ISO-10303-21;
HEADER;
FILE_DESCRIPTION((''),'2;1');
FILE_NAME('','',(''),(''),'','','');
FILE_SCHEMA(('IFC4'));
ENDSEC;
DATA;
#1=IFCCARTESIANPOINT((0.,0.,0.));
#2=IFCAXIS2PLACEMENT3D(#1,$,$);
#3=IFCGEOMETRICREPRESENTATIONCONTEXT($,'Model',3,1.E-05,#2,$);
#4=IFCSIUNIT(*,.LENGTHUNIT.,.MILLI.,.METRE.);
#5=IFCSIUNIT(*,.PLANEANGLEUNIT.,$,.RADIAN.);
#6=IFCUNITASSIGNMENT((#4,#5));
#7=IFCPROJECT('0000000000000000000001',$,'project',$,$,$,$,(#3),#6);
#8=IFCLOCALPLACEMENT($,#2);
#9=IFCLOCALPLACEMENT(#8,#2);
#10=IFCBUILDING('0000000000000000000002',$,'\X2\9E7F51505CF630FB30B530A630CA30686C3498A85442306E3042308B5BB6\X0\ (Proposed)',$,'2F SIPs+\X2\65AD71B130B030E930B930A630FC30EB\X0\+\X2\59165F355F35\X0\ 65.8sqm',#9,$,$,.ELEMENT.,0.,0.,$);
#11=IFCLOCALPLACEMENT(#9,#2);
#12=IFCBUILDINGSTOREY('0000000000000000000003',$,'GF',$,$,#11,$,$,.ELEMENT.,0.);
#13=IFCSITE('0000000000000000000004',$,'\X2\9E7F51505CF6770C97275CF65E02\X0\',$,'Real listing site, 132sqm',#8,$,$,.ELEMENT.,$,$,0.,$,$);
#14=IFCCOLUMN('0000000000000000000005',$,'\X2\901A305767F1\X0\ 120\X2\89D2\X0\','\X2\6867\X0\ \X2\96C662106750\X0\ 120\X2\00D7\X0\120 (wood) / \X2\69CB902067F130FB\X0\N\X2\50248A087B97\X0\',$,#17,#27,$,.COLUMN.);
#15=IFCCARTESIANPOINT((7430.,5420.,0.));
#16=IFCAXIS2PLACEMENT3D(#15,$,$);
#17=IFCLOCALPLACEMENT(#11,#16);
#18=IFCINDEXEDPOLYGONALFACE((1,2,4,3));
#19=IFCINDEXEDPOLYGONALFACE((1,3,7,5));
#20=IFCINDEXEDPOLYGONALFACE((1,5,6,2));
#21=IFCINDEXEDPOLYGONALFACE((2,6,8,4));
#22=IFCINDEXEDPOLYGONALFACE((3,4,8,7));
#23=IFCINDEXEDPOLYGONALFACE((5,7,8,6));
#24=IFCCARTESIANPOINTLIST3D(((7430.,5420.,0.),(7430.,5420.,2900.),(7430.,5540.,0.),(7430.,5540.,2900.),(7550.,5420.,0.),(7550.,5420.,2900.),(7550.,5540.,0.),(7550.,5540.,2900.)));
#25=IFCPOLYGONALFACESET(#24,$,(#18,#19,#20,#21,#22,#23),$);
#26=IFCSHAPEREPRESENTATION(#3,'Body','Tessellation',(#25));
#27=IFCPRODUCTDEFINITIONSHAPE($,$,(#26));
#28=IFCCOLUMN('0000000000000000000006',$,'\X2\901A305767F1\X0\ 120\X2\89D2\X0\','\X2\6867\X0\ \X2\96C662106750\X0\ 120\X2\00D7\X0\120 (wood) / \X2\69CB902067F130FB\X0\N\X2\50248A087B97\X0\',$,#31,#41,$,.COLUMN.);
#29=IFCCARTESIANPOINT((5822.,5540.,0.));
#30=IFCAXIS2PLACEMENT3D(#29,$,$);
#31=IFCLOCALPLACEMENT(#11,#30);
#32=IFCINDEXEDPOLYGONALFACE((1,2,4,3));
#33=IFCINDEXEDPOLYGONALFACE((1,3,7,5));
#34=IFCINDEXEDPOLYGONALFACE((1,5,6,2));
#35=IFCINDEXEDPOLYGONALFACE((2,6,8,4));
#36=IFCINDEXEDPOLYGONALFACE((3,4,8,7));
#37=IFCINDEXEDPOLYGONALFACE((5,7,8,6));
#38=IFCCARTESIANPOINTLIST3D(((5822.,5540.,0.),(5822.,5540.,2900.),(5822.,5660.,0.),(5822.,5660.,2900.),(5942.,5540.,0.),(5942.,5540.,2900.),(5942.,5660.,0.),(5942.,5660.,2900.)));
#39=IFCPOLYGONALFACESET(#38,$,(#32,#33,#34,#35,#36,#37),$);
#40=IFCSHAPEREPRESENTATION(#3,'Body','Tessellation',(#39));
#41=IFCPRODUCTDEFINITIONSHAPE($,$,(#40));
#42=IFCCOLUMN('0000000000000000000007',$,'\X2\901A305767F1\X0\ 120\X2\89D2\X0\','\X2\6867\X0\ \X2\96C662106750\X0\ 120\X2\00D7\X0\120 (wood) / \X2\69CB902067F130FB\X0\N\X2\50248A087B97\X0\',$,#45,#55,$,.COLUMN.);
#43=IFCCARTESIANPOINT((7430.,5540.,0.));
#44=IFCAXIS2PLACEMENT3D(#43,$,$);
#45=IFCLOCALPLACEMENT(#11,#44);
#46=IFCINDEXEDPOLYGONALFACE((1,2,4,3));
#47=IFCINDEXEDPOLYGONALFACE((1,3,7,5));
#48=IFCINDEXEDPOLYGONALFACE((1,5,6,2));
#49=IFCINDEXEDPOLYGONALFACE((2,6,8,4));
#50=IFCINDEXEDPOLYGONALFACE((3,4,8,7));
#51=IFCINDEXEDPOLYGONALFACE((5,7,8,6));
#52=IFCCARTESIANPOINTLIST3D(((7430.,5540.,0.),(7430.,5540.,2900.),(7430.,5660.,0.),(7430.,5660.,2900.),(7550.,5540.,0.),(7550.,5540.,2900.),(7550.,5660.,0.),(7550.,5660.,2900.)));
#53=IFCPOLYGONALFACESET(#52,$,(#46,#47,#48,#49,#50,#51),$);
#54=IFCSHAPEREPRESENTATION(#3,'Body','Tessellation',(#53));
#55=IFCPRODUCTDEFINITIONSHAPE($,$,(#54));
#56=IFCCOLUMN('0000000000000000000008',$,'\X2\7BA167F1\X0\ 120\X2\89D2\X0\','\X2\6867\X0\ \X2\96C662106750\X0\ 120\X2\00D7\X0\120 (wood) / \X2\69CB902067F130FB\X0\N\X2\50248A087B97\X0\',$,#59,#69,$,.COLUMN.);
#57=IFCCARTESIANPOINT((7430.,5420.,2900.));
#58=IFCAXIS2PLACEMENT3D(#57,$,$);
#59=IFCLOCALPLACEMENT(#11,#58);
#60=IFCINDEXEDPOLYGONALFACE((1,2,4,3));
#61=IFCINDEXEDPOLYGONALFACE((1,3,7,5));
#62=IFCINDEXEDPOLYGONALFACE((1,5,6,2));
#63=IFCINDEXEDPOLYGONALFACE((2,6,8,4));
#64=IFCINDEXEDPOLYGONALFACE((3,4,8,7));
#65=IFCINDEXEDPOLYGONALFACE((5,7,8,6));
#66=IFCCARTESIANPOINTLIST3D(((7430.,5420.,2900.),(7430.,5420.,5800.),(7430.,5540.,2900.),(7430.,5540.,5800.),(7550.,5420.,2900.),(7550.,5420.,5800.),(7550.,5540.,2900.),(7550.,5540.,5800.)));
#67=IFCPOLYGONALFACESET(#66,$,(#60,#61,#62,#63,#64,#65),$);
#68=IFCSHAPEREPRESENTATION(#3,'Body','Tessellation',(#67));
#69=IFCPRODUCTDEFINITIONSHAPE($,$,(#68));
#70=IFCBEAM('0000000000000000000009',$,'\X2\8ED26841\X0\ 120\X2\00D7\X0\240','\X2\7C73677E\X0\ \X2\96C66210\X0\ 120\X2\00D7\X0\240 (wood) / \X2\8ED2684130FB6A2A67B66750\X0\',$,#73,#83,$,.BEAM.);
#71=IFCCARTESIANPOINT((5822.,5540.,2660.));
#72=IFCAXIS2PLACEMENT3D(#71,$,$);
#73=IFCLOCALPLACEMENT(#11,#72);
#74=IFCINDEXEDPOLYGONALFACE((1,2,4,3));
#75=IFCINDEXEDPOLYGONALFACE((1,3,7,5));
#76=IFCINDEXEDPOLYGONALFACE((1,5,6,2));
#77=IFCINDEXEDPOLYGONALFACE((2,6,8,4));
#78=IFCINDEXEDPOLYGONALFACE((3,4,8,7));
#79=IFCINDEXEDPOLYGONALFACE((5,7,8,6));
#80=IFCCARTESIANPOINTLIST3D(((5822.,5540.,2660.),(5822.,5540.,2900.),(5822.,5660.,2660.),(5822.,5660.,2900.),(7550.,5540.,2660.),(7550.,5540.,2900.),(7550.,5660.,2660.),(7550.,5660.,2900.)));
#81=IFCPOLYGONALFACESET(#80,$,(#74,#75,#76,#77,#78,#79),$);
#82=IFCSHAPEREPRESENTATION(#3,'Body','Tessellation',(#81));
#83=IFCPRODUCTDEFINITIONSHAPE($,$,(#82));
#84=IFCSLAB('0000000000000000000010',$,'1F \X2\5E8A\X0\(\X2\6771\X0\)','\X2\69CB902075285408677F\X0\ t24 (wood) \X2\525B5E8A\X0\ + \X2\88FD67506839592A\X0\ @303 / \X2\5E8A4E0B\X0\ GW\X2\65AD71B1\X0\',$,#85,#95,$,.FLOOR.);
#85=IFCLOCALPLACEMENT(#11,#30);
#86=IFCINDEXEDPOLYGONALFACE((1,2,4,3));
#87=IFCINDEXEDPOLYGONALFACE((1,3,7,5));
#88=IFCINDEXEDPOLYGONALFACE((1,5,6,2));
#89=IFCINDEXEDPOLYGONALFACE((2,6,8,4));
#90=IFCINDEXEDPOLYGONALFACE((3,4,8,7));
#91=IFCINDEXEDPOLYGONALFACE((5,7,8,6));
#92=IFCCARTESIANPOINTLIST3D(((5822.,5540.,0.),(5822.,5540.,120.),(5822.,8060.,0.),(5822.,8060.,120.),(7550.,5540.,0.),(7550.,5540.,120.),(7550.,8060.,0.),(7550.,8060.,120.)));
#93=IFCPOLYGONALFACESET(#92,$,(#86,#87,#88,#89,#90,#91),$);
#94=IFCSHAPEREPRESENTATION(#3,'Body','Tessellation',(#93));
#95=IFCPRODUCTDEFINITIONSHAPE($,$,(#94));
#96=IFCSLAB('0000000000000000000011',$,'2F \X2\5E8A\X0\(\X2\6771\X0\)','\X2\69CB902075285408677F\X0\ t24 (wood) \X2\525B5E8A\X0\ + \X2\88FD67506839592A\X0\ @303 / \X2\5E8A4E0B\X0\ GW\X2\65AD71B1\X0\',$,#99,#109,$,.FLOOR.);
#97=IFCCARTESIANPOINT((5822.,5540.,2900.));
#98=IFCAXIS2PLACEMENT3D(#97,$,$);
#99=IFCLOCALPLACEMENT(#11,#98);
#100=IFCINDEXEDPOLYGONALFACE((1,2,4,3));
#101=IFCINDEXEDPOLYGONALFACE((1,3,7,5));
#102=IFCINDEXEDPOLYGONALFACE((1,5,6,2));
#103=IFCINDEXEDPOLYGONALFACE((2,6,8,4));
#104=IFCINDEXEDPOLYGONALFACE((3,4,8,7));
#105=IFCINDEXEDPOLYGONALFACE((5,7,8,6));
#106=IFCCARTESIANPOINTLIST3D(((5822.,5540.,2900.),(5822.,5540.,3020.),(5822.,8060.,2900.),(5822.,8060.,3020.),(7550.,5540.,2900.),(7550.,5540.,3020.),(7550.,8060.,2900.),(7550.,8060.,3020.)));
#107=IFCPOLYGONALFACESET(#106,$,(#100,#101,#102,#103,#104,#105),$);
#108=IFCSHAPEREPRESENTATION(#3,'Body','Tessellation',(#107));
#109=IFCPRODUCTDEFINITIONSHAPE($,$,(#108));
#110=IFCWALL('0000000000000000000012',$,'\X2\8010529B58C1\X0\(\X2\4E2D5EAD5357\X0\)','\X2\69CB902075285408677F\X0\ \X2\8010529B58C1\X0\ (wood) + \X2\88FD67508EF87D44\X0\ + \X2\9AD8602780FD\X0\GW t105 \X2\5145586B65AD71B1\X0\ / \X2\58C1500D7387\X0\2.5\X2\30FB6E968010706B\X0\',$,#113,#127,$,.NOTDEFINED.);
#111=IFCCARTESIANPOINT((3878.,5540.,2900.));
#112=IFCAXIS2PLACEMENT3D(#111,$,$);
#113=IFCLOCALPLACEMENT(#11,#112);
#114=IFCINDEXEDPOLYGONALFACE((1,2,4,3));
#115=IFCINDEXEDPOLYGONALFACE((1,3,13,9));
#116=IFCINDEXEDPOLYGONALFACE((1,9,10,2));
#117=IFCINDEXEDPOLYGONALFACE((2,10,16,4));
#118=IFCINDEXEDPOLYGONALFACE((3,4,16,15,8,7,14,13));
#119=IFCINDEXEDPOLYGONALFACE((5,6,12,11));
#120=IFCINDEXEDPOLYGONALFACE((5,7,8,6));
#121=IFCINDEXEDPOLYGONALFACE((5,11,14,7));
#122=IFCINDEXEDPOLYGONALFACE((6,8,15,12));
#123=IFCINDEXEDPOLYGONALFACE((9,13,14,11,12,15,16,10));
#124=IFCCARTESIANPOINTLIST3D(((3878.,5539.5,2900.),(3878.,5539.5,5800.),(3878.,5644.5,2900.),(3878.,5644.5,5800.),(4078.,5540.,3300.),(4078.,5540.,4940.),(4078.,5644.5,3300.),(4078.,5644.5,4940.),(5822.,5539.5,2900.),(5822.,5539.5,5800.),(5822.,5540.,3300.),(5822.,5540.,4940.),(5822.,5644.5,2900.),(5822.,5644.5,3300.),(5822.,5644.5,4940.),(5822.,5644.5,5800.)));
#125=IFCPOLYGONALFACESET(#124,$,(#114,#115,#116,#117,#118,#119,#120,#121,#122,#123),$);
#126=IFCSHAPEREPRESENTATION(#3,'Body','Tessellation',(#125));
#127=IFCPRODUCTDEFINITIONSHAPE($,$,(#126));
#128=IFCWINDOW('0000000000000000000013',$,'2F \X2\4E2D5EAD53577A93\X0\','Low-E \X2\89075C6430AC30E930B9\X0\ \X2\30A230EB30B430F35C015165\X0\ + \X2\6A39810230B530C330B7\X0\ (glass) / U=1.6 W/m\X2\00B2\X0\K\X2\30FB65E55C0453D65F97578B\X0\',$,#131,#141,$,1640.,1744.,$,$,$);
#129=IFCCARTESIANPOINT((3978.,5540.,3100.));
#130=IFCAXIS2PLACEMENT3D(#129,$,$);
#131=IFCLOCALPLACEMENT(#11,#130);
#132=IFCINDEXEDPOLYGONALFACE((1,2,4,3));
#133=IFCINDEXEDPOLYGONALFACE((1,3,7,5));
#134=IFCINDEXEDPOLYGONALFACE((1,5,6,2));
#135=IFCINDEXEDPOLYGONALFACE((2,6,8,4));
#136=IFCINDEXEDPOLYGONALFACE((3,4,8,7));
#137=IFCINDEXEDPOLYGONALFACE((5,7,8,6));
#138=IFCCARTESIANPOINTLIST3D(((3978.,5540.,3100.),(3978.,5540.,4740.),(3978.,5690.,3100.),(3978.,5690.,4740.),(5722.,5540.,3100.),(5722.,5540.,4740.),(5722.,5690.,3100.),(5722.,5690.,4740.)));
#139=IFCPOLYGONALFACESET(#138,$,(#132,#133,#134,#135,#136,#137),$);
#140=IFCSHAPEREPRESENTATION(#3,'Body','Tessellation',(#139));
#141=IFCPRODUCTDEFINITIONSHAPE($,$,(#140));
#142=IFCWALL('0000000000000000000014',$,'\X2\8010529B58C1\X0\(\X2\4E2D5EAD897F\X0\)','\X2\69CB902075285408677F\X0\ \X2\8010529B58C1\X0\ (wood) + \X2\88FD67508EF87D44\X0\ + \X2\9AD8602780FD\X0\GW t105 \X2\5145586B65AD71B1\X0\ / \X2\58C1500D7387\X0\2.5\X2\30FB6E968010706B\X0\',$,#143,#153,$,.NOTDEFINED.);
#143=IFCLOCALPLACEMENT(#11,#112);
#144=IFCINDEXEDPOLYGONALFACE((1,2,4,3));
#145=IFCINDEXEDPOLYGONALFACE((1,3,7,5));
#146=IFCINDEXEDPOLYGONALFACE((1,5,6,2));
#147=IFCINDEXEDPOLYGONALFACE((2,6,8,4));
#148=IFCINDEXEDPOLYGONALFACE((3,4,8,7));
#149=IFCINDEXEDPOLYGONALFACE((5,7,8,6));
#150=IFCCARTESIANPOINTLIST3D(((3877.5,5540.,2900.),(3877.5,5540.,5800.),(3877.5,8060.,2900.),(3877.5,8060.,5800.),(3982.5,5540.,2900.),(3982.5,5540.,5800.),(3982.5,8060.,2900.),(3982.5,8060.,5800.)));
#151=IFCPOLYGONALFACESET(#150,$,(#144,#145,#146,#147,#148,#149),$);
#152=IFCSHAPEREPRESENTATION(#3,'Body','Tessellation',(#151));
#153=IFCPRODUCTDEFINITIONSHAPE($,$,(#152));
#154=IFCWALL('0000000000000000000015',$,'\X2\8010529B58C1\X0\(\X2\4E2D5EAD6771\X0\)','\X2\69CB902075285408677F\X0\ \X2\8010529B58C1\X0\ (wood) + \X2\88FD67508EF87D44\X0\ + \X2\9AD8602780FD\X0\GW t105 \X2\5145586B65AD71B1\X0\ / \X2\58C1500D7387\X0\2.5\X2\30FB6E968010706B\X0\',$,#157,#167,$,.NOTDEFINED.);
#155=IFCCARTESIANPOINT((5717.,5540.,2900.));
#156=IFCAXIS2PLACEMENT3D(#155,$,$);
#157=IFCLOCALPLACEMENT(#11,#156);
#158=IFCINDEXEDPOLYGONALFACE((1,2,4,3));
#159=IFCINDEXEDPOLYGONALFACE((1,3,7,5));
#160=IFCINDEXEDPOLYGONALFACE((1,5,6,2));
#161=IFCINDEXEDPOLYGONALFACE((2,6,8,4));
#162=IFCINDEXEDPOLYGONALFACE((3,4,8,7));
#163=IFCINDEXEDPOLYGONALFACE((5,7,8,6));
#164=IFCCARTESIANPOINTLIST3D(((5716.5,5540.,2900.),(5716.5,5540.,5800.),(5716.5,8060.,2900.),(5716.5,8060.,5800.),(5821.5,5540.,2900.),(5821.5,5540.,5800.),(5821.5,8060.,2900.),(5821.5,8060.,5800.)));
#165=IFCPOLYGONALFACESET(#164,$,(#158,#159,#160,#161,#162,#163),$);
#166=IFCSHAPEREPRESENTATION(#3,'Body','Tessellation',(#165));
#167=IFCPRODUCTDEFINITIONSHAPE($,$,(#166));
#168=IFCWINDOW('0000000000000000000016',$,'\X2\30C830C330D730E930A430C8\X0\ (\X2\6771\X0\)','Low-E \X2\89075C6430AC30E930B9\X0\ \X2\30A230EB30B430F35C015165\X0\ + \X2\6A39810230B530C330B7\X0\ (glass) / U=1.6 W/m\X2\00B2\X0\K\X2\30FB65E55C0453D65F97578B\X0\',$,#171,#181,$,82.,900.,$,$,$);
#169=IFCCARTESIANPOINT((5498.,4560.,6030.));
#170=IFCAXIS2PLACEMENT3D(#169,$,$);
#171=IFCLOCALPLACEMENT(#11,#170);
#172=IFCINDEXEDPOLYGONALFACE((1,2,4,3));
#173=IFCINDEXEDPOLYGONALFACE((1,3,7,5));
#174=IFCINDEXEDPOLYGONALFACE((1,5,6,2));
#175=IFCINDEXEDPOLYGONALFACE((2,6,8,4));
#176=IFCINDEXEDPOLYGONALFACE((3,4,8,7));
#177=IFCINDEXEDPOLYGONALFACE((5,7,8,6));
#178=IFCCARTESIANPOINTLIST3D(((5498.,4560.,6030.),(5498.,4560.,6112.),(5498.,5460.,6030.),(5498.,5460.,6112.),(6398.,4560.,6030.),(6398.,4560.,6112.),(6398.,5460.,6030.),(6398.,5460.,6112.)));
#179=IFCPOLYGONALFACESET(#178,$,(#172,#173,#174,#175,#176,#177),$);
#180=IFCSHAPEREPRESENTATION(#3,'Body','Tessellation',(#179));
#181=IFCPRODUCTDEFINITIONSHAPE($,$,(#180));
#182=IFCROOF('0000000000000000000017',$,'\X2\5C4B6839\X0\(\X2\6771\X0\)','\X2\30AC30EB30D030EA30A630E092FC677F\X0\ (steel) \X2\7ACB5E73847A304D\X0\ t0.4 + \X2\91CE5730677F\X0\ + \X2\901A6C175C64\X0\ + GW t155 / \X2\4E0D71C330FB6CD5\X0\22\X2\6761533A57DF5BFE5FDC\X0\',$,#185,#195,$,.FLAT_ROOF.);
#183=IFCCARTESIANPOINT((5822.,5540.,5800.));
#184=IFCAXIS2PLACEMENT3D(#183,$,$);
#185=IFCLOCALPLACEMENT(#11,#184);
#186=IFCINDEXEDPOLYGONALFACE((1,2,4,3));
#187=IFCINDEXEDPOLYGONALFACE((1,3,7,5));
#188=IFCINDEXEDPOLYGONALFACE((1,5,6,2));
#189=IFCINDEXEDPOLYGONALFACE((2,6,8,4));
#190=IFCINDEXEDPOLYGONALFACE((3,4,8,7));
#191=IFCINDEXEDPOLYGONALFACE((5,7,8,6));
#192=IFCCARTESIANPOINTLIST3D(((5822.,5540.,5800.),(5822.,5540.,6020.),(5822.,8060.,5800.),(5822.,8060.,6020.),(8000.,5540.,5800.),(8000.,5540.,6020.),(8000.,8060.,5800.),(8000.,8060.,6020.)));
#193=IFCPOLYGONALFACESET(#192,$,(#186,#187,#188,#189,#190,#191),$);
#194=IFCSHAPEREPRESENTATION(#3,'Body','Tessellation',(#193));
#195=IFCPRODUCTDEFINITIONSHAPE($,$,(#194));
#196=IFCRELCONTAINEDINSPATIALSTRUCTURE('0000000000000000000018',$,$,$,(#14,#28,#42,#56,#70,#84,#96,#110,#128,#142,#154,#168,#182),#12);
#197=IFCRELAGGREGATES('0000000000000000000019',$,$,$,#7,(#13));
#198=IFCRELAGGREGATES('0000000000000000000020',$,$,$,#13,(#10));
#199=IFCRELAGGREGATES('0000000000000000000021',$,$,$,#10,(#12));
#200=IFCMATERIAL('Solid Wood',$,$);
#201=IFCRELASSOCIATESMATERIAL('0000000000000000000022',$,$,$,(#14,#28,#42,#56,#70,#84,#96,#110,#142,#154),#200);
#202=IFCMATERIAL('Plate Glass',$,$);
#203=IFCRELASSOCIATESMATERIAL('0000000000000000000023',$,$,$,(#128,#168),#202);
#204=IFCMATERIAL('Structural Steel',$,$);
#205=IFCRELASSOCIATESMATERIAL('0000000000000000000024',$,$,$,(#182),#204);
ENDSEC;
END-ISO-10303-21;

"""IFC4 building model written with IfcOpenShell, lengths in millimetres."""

from ifc_helpers import new_model, si_unit, frame, frame_2d, origin, place, context, project, spatial, rectangle, extrude, material, element, fill, save


model = new_model("IFC4")

# Units and contexts
model_context = context("Model", 3, precision=1e-05, world=origin())
ifc_project = project(units=[si_unit("LENGTHUNIT", "METRE", prefix="MILLI"), si_unit("PLANEANGLEUNIT", "RADIAN")], contexts=[model_context])

# Site, building, storey
site_placement = place(None, origin())
site = spatial("IfcSite", under=ifc_project, at=site_placement, Name="鹿児島県霧島市", ObjectType="Real listing site, 132sqm", CompositionType="ELEMENT", RefElevation=0.0)
building_placement = place(site_placement, origin())
building = spatial("IfcBuilding", under=site, at=building_placement, Name="鹿児島・サウナと水風呂のある家 (Proposed)", ObjectType="2F SIPs+断熱グラスウール+外張張 65.8sqm", CompositionType="ELEMENT", ElevationOfRefHeight=0.0, ElevationOfTerrain=0.0)
storey_placement = place(building_placement, origin())
storey = spatial("IfcBuildingStorey", under=building, at=storey_placement, Name="GF", CompositionType="ELEMENT", Elevation=0.0)

# Columns
ifc_material_1 = material(Name="Solid Wood")
column_1_placement = place(storey_placement, frame((7430.0, 5420.0, 0.0)))
element("IfcColumn", 1, at=column_1_placement, inside=storey, material=ifc_material_1, Name="通し柱 120角", Description="桧 集成材 120×120 (wood) / 構造柱・N値計算", PredefinedType="COLUMN", context=model_context, shape_type="SweptSolid", body=[
    extrude(rectangle(XDim=120.0, YDim=120.0, at=frame_2d((60.0, 60.0))), frame((7430.0, 5420.0, 0.0)), (0.0, 0.0, 1.0), 2900.0),
])
column_2_placement = place(storey_placement, frame((5822.0, 5540.0, 0.0)))
element("IfcColumn", 2, at=column_2_placement, inside=storey, material=ifc_material_1, Name="通し柱 120角", Description="桧 集成材 120×120 (wood) / 構造柱・N値計算", PredefinedType="COLUMN", context=model_context, shape_type="SweptSolid", body=[
    extrude(rectangle(XDim=120.0, YDim=120.0, at=frame_2d((60.0, 60.0))), frame((5822.0, 5540.0, 0.0)), (0.0, 0.0, 1.0), 2900.0),
])
column_3_placement = place(storey_placement, frame((7430.0, 5540.0, 0.0)))
element("IfcColumn", 3, at=column_3_placement, inside=storey, material=ifc_material_1, Name="通し柱 120角", Description="桧 集成材 120×120 (wood) / 構造柱・N値計算", PredefinedType="COLUMN", context=model_context, shape_type="SweptSolid", body=[
    extrude(rectangle(XDim=120.0, YDim=120.0, at=frame_2d((60.0, 60.0))), frame((7430.0, 5540.0, 0.0)), (0.0, 0.0, 1.0), 2900.0),
])
column_4_placement = place(storey_placement, frame((7430.0, 5420.0, 2900.0)))
element("IfcColumn", 4, at=column_4_placement, inside=storey, material=ifc_material_1, Name="管柱 120角", Description="桧 集成材 120×120 (wood) / 構造柱・N値計算", PredefinedType="COLUMN", context=model_context, shape_type="SweptSolid", body=[
    extrude(rectangle(XDim=120.0, YDim=120.0, at=frame_2d((60.0, 60.0))), frame((7430.0, 5420.0, 2900.0)), (0.0, 0.0, 1.0), 2900.0),
])

# Beam
beam_1_placement = place(storey_placement, frame((5822.0, 5540.0, 2660.0)))
element("IfcBeam", 5, at=beam_1_placement, inside=storey, material=ifc_material_1, Name="軒桁 120×240", Description="米松 集成 120×240 (wood) / 軒桁・横架材", PredefinedType="BEAM", context=model_context, shape_type="SweptSolid", body=[
    extrude(rectangle(XDim=1728.0, YDim=120.0, at=frame_2d((864.0, 60.0))), frame((5822.0, 5540.0, 2660.0)), (0.0, 0.0, 1.0), 240.0),
])

# Slabs
slab_1_placement = place(storey_placement, frame((5822.0, 5540.0, 0.0)))
element("IfcSlab", 6, at=slab_1_placement, inside=storey, material=ifc_material_1, Name="1F 床(東)", Description="構造用合板 t24 (wood) 剛床 + 製材根太 @303 / 床下 GW断熱", PredefinedType="FLOOR", context=model_context, shape_type="SweptSolid", body=[
    extrude(rectangle(XDim=1728.0, YDim=2520.0, at=frame_2d((864.0, 1260.0))), frame((5822.0, 5540.0, 0.0)), (0.0, 0.0, 1.0), 120.0),
])
slab_2_placement = place(storey_placement, frame((5822.0, 5540.0, 2900.0)))
element("IfcSlab", 7, at=slab_2_placement, inside=storey, material=ifc_material_1, Name="2F 床(東)", Description="構造用合板 t24 (wood) 剛床 + 製材根太 @303 / 床下 GW断熱", PredefinedType="FLOOR", context=model_context, shape_type="SweptSolid", body=[
    extrude(rectangle(XDim=1728.0, YDim=2520.0, at=frame_2d((864.0, 1260.0))), frame((5822.0, 5540.0, 2900.0)), (0.0, 0.0, 1.0), 120.0),
])

# Wall, opening, window
wall_1_placement = place(storey_placement, frame((3878.0, 5540.0, 2900.0)))
wall_1 = element("IfcWall", 8, at=wall_1_placement, inside=storey, material=ifc_material_1, Name="耐力壁(中庭南)", Description="構造用合板 耐力壁 (wood) + 製材軸組 + 高性能GW t105 充填断熱 / 壁倍率2.5・準耐火", PredefinedType="NOTDEFINED", context=model_context, shape_type="SweptSolid", body=[
    extrude(rectangle(XDim=1944.0, YDim=105.0, at=frame_2d((972.0, 52.0))), frame((3878.0, 5540.0, 2900.0)), (0.0, 0.0, 1.0), 2900.0),
])
opening_placement = place(storey_placement, frame((3978.0, 5540.0, 3100.0)))
opening = element("IfcOpeningElement", 9, at=opening_placement, cuts=wall_1, PredefinedType="NOTDEFINED", context=model_context, shape_type="SweptSolid", body=[
    extrude(rectangle(XDim=1744.0, YDim=150.0, at=frame_2d((872.0, 75.0))), frame((3978.0, 5540.0, 3100.0)), (0.0, 0.0, 1.0), 1640.0),
])
ifc_material_2 = material(Name="Plate Glass")
window_1_placement = place(storey_placement, frame((3978.0, 5540.0, 3100.0)))
window_1 = element("IfcWindow", 10, at=window_1_placement, inside=storey, material=ifc_material_2, Name="2F 中庭南窓", Description="Low-E 複層ガラス アルゴン封入 + 樹脂サッシ (glass) / U=1.6 W/m²K・日射取得型", OverallHeight=1640.0, OverallWidth=1744.0, context=model_context, shape_type="SweptSolid", body=[
    extrude(rectangle(XDim=1744.0, YDim=150.0, at=frame_2d((872.0, 75.0))), frame((3978.0, 5540.0, 3100.0)), (0.0, 0.0, 1.0), 1640.0),
])
fill(opening, window_1)

# Walls
wall_2_placement = place(storey_placement, frame((3878.0, 5540.0, 2900.0)))
element("IfcWall", 11, at=wall_2_placement, inside=storey, material=ifc_material_1, Name="耐力壁(中庭西)", Description="構造用合板 耐力壁 (wood) + 製材軸組 + 高性能GW t105 充填断熱 / 壁倍率2.5・準耐火", PredefinedType="NOTDEFINED", context=model_context, shape_type="SweptSolid", body=[
    extrude(rectangle(XDim=105.0, YDim=2520.0, at=frame_2d((52.0, 1260.0))), frame((3878.0, 5540.0, 2900.0)), (0.0, 0.0, 1.0), 2900.0),
])
wall_3_placement = place(storey_placement, frame((5717.0, 5540.0, 2900.0)))
element("IfcWall", 12, at=wall_3_placement, inside=storey, material=ifc_material_1, Name="耐力壁(中庭東)", Description="構造用合板 耐力壁 (wood) + 製材軸組 + 高性能GW t105 充填断熱 / 壁倍率2.5・準耐火", PredefinedType="NOTDEFINED", context=model_context, shape_type="SweptSolid", body=[
    extrude(rectangle(XDim=105.0, YDim=2520.0, at=frame_2d((52.0, 1260.0))), frame((5717.0, 5540.0, 2900.0)), (0.0, 0.0, 1.0), 2900.0),
])

# Window
window_2_placement = place(storey_placement, frame((5498.0, 4560.0, 6030.0)))
element("IfcWindow", 13, at=window_2_placement, inside=storey, material=ifc_material_2, Name="トップライト (東)", Description="Low-E 複層ガラス アルゴン封入 + 樹脂サッシ (glass) / U=1.6 W/m²K・日射取得型", OverallHeight=82.0, OverallWidth=900.0, context=model_context, shape_type="SweptSolid", body=[
    extrude(rectangle(XDim=900.0, YDim=900.0, at=frame_2d((450.0, 450.0))), frame((5498.0, 4560.0, 6030.0)), (0.0, 0.0, 1.0), 82.0),
])

# Roof
ifc_material_3 = material(Name="Structural Steel")
for number, where, name in (
    (14, (5822.0, 5540.0, 5800.0), "屋根(東)"),
):
    element("IfcRoof", number, at=place(storey_placement, frame(where)), inside=storey, material=ifc_material_3, Name=name, Description="ガルバリウム鋼板 (steel) 立平葺き t0.4 + 野地板 + 通気層 + GW t155 / 不燃・法22条区域対応", PredefinedType="FLAT_ROOF", context=model_context, shape_type="SweptSolid", body=[
        extrude(rectangle(XDim=2178.0, YDim=2520.0, at=frame_2d((1089.0, 1260.0))), frame((5822.0, 5540.0, 5800.0)), (0.0, 0.0, 1.0), 220.0),
    ])

save(model, "model.ifc")
